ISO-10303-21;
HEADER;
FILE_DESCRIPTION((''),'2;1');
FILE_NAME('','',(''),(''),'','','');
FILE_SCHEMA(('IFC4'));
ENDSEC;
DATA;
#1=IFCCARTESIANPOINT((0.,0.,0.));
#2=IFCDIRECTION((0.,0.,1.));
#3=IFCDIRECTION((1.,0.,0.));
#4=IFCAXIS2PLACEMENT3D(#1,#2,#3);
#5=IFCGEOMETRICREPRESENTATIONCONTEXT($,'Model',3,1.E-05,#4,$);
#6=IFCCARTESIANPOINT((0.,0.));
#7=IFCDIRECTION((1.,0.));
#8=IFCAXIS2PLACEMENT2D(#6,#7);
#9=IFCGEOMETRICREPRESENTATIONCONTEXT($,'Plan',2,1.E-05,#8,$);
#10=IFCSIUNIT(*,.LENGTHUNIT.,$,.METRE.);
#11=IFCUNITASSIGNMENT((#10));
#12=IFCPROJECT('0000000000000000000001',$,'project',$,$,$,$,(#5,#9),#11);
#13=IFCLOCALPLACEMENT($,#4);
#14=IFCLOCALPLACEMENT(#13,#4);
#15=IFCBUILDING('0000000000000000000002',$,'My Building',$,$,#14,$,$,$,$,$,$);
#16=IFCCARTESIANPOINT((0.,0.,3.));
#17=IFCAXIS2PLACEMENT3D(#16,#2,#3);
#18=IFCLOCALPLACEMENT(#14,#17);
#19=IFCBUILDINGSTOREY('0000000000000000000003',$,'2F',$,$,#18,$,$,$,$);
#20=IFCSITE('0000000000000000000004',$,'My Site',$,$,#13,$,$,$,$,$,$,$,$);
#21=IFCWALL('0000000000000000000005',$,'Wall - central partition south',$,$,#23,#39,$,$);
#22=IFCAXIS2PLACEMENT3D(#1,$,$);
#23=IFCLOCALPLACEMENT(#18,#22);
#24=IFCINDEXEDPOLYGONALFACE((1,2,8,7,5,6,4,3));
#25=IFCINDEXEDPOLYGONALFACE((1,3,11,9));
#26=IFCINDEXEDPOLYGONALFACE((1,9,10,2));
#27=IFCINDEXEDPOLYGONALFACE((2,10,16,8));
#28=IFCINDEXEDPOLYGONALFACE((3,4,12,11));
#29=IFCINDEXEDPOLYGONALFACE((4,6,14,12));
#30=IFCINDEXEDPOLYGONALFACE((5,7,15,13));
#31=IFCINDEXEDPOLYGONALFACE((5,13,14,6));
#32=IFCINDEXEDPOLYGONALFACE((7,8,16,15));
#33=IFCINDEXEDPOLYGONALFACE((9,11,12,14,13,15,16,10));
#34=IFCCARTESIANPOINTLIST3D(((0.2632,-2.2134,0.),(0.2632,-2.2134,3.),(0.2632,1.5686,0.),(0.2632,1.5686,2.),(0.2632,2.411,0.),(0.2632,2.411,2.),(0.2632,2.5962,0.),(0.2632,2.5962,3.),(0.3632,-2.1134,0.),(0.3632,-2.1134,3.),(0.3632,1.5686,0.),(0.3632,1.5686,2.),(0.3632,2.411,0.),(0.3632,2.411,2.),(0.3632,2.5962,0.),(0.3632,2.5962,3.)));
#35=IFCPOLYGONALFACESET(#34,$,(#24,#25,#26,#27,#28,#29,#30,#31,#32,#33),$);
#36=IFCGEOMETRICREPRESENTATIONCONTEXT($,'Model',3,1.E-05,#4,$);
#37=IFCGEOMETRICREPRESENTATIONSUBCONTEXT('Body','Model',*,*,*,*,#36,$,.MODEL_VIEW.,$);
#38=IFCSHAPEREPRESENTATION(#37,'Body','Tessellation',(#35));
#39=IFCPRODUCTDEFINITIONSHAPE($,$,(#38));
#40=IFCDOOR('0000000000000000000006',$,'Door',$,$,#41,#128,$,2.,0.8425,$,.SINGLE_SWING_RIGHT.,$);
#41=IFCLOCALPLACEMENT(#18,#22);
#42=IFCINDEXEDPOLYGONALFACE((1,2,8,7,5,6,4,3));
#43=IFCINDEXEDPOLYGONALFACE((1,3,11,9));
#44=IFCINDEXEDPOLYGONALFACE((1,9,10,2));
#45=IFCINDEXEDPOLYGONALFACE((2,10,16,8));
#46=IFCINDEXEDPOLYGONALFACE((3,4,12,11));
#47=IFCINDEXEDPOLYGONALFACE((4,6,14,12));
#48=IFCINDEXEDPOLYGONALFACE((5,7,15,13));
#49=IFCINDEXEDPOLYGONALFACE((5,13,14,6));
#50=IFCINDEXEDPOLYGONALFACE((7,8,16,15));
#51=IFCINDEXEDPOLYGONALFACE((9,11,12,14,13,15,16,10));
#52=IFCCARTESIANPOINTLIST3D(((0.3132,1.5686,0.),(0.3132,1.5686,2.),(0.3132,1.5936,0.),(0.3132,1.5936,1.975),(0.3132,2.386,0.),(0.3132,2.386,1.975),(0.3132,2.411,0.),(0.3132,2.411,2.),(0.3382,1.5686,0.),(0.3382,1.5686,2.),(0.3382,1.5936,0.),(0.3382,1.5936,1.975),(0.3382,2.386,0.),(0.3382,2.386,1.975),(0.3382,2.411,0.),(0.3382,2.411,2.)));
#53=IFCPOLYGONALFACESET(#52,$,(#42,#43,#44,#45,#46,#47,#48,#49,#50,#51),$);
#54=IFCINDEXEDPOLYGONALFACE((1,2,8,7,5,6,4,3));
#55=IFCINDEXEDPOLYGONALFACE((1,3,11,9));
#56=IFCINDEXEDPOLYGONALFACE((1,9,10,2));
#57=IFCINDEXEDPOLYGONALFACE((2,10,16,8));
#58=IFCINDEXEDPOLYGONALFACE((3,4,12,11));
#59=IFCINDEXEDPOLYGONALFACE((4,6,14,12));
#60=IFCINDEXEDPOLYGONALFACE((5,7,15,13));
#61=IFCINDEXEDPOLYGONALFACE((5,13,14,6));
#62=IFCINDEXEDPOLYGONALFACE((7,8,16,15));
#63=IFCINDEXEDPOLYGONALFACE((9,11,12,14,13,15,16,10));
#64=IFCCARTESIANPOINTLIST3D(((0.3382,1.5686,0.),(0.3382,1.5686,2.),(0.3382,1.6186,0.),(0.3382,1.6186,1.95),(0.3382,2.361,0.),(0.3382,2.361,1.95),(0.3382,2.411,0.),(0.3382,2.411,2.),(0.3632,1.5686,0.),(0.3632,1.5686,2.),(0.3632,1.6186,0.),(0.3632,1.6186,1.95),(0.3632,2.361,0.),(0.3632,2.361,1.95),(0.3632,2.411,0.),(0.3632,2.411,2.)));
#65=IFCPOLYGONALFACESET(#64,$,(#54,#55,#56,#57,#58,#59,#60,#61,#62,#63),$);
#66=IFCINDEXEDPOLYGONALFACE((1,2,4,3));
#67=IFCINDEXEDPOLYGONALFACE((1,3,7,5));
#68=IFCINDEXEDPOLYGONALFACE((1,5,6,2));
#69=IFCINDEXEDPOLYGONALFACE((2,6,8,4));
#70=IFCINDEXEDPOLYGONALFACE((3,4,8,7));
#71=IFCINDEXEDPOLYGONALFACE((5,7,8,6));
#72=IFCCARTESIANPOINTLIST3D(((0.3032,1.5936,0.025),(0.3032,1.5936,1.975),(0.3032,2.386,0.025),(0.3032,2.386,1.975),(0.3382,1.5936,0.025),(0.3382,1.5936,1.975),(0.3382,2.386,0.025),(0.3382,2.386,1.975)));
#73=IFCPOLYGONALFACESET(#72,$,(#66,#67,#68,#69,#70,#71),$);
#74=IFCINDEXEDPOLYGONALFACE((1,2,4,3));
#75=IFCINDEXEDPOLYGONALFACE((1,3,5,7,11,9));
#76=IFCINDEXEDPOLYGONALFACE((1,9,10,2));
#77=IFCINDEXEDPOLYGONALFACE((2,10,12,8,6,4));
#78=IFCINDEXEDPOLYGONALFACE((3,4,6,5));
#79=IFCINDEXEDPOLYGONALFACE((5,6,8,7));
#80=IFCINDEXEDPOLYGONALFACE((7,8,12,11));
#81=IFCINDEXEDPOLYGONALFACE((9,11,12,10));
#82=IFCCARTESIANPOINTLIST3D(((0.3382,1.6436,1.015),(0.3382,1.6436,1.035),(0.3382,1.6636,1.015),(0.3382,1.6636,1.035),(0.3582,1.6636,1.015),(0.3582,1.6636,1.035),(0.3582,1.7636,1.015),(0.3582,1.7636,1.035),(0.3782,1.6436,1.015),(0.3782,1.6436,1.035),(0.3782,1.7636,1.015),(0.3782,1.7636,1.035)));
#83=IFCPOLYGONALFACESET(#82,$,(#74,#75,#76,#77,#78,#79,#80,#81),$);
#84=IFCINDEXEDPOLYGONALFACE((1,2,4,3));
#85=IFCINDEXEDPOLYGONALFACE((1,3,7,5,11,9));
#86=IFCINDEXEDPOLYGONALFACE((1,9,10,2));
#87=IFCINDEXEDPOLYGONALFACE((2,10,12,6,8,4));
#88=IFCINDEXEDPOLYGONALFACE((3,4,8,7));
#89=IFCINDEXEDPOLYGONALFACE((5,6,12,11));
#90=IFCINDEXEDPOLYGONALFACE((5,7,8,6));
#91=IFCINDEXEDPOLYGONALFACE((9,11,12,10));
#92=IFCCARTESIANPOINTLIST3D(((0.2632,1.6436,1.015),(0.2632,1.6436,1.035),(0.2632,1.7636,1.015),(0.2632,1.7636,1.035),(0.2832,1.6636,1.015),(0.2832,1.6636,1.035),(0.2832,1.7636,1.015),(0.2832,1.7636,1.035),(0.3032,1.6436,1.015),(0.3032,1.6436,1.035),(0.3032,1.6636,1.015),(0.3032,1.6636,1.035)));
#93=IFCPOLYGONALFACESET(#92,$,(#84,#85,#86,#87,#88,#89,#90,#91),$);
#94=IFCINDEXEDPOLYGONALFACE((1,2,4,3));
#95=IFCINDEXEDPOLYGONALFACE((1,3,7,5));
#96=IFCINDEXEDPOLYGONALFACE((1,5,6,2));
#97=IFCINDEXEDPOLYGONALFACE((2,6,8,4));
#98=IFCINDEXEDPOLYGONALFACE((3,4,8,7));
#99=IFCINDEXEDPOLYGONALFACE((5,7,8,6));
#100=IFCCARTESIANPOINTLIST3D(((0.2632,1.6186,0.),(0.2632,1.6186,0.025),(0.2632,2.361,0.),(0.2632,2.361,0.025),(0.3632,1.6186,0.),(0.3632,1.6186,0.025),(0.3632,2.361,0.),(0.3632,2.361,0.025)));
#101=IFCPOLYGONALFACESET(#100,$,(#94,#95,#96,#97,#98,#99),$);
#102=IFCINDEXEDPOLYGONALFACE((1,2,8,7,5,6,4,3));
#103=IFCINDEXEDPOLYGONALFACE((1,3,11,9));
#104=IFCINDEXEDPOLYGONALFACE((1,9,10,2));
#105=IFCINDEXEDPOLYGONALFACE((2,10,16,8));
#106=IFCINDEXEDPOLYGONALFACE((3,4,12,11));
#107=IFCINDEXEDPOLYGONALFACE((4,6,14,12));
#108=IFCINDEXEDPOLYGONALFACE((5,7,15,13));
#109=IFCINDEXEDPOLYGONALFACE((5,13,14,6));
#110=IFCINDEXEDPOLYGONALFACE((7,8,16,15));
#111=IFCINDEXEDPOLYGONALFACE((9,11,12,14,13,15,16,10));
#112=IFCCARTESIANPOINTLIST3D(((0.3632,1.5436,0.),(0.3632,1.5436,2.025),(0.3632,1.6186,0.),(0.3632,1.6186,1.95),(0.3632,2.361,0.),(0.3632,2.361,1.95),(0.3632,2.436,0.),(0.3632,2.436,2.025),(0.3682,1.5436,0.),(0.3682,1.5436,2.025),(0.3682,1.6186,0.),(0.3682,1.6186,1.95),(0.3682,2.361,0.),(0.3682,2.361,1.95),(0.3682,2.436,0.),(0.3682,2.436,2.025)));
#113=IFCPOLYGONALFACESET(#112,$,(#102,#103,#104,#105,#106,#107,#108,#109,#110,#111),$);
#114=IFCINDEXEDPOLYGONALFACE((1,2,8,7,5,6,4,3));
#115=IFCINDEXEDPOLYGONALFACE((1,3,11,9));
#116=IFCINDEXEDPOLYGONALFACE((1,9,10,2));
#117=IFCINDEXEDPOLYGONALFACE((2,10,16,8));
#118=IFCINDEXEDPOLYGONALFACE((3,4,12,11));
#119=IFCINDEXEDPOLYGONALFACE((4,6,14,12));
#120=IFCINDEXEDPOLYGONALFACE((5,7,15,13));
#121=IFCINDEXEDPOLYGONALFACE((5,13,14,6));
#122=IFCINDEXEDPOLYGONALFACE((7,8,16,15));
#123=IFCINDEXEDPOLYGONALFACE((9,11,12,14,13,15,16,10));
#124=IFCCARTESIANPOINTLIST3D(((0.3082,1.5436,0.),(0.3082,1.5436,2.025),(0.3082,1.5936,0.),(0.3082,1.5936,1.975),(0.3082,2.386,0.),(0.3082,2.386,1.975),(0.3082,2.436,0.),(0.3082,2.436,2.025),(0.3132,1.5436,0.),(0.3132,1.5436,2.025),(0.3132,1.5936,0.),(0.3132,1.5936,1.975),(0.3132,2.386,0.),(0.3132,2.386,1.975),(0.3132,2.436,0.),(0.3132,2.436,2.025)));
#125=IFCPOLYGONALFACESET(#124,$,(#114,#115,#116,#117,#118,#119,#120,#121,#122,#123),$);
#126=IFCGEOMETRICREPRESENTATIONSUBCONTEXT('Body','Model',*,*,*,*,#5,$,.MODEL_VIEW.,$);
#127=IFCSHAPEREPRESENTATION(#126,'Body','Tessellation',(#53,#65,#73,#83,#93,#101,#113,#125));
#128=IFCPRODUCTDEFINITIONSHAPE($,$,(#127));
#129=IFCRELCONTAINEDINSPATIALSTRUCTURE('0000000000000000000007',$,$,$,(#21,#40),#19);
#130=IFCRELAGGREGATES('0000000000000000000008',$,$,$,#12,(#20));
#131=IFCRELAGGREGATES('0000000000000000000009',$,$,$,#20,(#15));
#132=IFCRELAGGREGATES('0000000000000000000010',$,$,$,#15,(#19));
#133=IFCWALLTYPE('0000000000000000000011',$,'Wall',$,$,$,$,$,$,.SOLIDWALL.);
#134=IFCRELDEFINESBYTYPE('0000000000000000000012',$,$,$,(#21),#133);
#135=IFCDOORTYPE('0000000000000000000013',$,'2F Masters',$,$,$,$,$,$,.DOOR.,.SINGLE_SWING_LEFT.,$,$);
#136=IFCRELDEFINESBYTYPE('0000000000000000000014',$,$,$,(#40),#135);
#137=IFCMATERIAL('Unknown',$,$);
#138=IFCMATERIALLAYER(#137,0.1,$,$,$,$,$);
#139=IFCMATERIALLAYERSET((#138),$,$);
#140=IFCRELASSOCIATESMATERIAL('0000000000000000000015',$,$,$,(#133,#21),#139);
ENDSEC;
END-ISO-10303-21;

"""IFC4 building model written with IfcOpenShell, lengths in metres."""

from ifc_helpers import new_model, entity, si_unit, frame, origin_with_axes, origin_2d_with_axis, place, context, subcontext, project, spatial, line, indexed_curve, outline, extrude, shape, source, transform, mapped, material, layer, layer_set, layer_usage, type_object, type_shapes, element, fill, save


model = new_model("IFC4")

# Units and contexts
model_context_1 = context("Model", 3, precision=1e-05, world=origin_with_axes())
plan_context = context("Plan", 2, precision=1e-05, world=origin_2d_with_axis())
model_context_2 = context("Model", 3, precision=1e-05, world=origin_with_axes())
body_context_1 = subcontext(model_context_1, "Body", "Model", "MODEL_VIEW")
body_context_2 = subcontext(plan_context, "Body", "Plan", "PLAN_VIEW")
body_context_3 = subcontext(model_context_2, "Body", "Model", "MODEL_VIEW")
ifc_project = project(units=[si_unit("LENGTHUNIT", "METRE")], contexts=[model_context_1, plan_context])

# Site, building, storey
site_placement = place(None, origin_with_axes())
site = spatial("IfcSite", under=ifc_project, at=site_placement, Name="My Site")
building_placement = place(site_placement, origin_with_axes())
building = spatial("IfcBuilding", under=site, at=building_placement, Name="My Building")
storey_placement = place(building_placement, frame((0.0, 0.0, 3.0), z_axis=(0.0, 0.0, 1.0), x_axis=(1.0, 0.0, 0.0)))
storey = spatial("IfcBuildingStorey", under=building, at=storey_placement, Name="2F")

# Shared definitions
ifc_material_1 = material(Name="Unknown")
ifc_layer = layer(ifc_material_1, 0.1)
ifc_layer_set = layer_set([ifc_layer])
wall_type = type_object("IfcWallType", Name="Wall", PredefinedType="SOLIDWALL", material=ifc_layer_set)

# Wall, opening, door
ifc_layer_usage_1 = layer_usage(ifc_layer_set, "AXIS2", "POSITIVE", 0.0)
wall_1_placement = place(storey_placement, frame((0.2632, 2.5962, 0.0), z_axis=(0.0, 0.0, 1.0), x_axis=(0.0, -1.0, 0.0)))
wall_1 = element("IfcWall", 1, at=wall_1_placement, inside=storey, type_object=wall_type, material=ifc_layer_usage_1, Name="Wall - central partition south", context=body_context_3, shape_type="SweptSolid", body=[
    extrude(outline(indexed_curve([(0.0, 0.1), (4.7096, 0.1), (4.8096, 0.0), (0.0, 0.0)], segments=[line(1, 2, 3, 4, 1)])), origin_with_axes(), (0.0, 0.0, 1.0), 3.0),
])
shared_shape_1 = source(origin_with_axes(), body_context_1, "Body", "SweptSolid", [
    extrude(outline(indexed_curve([(0.0, 0.0), (0.8425, 0.0), (0.8425, 2.0), (0.0, 2.0)], segments=[line(1, 2, 3, 4, 1)])), frame((0.0, -0.6, 0.0), z_axis=(0.0, -1.0, 0.0), x_axis=(1.0, 0.0, 0.0)), (0.0, 0.0, -1.0), 1.2),
])
opening_1_placement = place(wall_1_placement, frame((1.0277, 0.1, 0.0), z_axis=(0.0, 0.0, 1.0), x_axis=(-1.0, 0.0, 0.0)))
opening_1 = element("IfcOpeningElement", 2, at=opening_1_placement, cuts=wall_1, PredefinedType="OPENING", context=body_context_1, shape_type="MappedRepresentation", body=[
    mapped(shared_shape_1, transform((0.0, 0.0, 0.0), x_axis=(1.0, 0.0, 0.0), y_axis=(0.0, 1.0, 0.0), z_axis=(0.0, 0.0, 1.0), scale=1.0)),
])
door_type_1 = type_object("IfcDoorType", Name="2F Masters", OperationType="SINGLE_SWING_LEFT", PredefinedType="DOOR")
shared_shape_2 = source(origin_with_axes(), body_context_1, "Body", "SweptSolid", [
    extrude(outline(indexed_curve([(0.0, 0.0), (0.0, 2.0), (0.8425, 2.0), (0.8425, 0.0), (0.8175, 0.0), (0.8175, 1.975), (0.025, 1.975), (0.025, 0.0)], segments=[line(1, 2, 3, 4, 5, 6, 7, 8, 1)])), frame((0.0, 0.025, 0.0), z_axis=(0.0, -1.0, 0.0), x_axis=(1.0, 0.0, 0.0)), (0.0, 0.0, -1.0), 0.025),
    extrude(outline(indexed_curve([(0.0, 0.0), (0.0, 2.0), (0.8425, 2.0), (0.8425, 0.0), (0.7925, 0.0), (0.7925, 1.95), (0.05, 1.95), (0.05, 0.0)], segments=[line(1, 2, 3, 4, 5, 6, 7, 8, 1)])), frame((0.0, 0.0, 0.0), z_axis=(0.0, -1.0, 0.0), x_axis=(1.0, 0.0, 0.0)), (0.0, 0.0, -1.0), 0.025),
    extrude(outline(indexed_curve([(0.0, 0.0), (0.7925, 0.0), (0.7925, 0.035), (0.0, 0.035)], segments=[line(1, 2, 3, 4, 1)])), frame((0.025, 0.025, 0.025), z_axis=(0.0, 0.0, 1.0), x_axis=(1.0, 0.0, 0.0)), (0.0, 0.0, 1.0), 1.95),
    extrude(outline(indexed_curve([(0.0, 0.0), (0.0, -0.04), (0.12, -0.04), (0.12, -0.02), (0.02, -0.02), (0.02, 0.0)], segments=[line(1, 2, 3, 4, 5, 6, 1)])), frame((0.075, 0.025, 1.015), z_axis=(0.0, 0.0, 1.0), x_axis=(1.0, 0.0, 0.0)), (0.0, 0.0, 1.0), 0.02),
    extrude(outline(indexed_curve([(0.0, 0.0), (0.0, 0.04), (0.12, 0.04), (0.12, 0.02), (0.02, 0.02), (0.02, 0.0)], segments=[line(1, 2, 3, 4, 5, 6, 1)])), frame((0.075, 0.06, 1.015), z_axis=(0.0, 0.0, 1.0), x_axis=(1.0, 0.0, 0.0)), (0.0, 0.0, 1.0), 0.02),
    extrude(outline(indexed_curve([(0.0, 0.0), (0.7425, 0.0), (0.7425, 0.1), (0.0, 0.1)], segments=[line(1, 2, 3, 4, 1)])), frame((0.05, 0.0, 0.0), z_axis=(0.0, 0.0, 1.0), x_axis=(1.0, 0.0, 0.0)), (0.0, 0.0, 1.0), 0.025),
    extrude(outline(indexed_curve([(0.0, 0.0), (0.0, 2.025), (0.8925, 2.025), (0.8925, 0.0), (0.8175, 0.0), (0.8175, 1.95), (0.075, 1.95), (0.075, 0.0)], segments=[line(1, 2, 3, 4, 5, 6, 7, 8, 1)])), frame((-0.025, -0.005, 0.0), z_axis=(0.0, -1.0, 0.0), x_axis=(1.0, 0.0, 0.0)), (0.0, 0.0, -1.0), 0.005),
    extrude(outline(indexed_curve([(0.0, 0.0), (0.0, 2.025), (0.8925, 2.025), (0.8925, 0.0), (0.8425, 0.0), (0.8425, 1.975), (0.05, 1.975), (0.05, 0.0)], segments=[line(1, 2, 3, 4, 5, 6, 7, 8, 1)])), frame((-0.025, 0.05, 0.0), z_axis=(0.0, -1.0, 0.0), x_axis=(1.0, 0.0, 0.0)), (0.0, 0.0, -1.0), 0.005),
])
shared_shape_3 = source(origin_with_axes(), body_context_2, "Body", "Curve2D", [
    entity("IfcIndexedPolyCurve", entity("IfcCartesianPointList2D", [[0.0, 0.0], [0.0, 0.05], [0.025, 0.05], [0.025, 0.025], [0.05, 0.025], [0.05, 0.0]]), [entity("IfcLineIndex", [1, 2, 3, 4, 5, 6, 1])]),
    entity("IfcIndexedPolyCurve", entity("IfcCartesianPointList2D", [[0.8425, 0.0], [0.8425, 0.05], [0.8175, 0.05], [0.8175, 0.025], [0.7925, 0.025], [0.7925, 0.0]]), [entity("IfcLineIndex", [1, 2, 3, 4, 5, 6, 1])]),
    entity("IfcTrimmedCurve", entity("IfcEllipse", entity("IfcAxis2Placement2D", entity("IfcCartesianPoint", [0.7825, 0.05]), entity("IfcDirection", [1.0, 0.0])), 0.7575, 0.7925), [entity("IfcCartesianPoint", [0.7825, 0.8425])], [entity("IfcCartesianPoint", [0.025, 0.05])], True, "CARTESIAN"),
    entity("IfcIndexedPolyCurve", entity("IfcCartesianPointList2D", [[0.8175, 0.05], [0.7825, 0.05], [0.7825, 0.8425], [0.8175, 0.8425]]), [entity("IfcLineIndex", [1, 2, 3, 4, 1])]),
])
type_shapes(door_type_1, [shared_shape_2, shared_shape_3])
door_1_placement = place(opening_1_placement, frame((0.0, 0.0, 0.0), z_axis=(0.0, 0.0, 1.0), x_axis=(1.0, 0.0, 0.0)))
door_1 = element("IfcDoor", 3, at=door_1_placement, inside=storey, type_object=door_type_1, Name="Door", OperationType="SINGLE_SWING_RIGHT", OverallHeight=2.0, OverallWidth=0.8425, shapes=[
    shape(body_context_1, "Body", "MappedRepresentation", [mapped(shared_shape_2, transform((0.0, 0.0, 0.0), x_axis=(1.0, 0.0, 0.0), y_axis=(0.0, 1.0, 0.0), z_axis=(0.0, 0.0, 1.0), scale=1.0))]),
    shape(body_context_2, "Body", "MappedRepresentation", [mapped(shared_shape_3, transform((0.0, 0.0, 0.0), x_axis=(1.0, 0.0, 0.0), y_axis=(0.0, 1.0, 0.0), z_axis=(0.0, 0.0, 1.0), scale=1.0))]),
])
fill(opening_1, door_1)

save(model, "model.ifc")
